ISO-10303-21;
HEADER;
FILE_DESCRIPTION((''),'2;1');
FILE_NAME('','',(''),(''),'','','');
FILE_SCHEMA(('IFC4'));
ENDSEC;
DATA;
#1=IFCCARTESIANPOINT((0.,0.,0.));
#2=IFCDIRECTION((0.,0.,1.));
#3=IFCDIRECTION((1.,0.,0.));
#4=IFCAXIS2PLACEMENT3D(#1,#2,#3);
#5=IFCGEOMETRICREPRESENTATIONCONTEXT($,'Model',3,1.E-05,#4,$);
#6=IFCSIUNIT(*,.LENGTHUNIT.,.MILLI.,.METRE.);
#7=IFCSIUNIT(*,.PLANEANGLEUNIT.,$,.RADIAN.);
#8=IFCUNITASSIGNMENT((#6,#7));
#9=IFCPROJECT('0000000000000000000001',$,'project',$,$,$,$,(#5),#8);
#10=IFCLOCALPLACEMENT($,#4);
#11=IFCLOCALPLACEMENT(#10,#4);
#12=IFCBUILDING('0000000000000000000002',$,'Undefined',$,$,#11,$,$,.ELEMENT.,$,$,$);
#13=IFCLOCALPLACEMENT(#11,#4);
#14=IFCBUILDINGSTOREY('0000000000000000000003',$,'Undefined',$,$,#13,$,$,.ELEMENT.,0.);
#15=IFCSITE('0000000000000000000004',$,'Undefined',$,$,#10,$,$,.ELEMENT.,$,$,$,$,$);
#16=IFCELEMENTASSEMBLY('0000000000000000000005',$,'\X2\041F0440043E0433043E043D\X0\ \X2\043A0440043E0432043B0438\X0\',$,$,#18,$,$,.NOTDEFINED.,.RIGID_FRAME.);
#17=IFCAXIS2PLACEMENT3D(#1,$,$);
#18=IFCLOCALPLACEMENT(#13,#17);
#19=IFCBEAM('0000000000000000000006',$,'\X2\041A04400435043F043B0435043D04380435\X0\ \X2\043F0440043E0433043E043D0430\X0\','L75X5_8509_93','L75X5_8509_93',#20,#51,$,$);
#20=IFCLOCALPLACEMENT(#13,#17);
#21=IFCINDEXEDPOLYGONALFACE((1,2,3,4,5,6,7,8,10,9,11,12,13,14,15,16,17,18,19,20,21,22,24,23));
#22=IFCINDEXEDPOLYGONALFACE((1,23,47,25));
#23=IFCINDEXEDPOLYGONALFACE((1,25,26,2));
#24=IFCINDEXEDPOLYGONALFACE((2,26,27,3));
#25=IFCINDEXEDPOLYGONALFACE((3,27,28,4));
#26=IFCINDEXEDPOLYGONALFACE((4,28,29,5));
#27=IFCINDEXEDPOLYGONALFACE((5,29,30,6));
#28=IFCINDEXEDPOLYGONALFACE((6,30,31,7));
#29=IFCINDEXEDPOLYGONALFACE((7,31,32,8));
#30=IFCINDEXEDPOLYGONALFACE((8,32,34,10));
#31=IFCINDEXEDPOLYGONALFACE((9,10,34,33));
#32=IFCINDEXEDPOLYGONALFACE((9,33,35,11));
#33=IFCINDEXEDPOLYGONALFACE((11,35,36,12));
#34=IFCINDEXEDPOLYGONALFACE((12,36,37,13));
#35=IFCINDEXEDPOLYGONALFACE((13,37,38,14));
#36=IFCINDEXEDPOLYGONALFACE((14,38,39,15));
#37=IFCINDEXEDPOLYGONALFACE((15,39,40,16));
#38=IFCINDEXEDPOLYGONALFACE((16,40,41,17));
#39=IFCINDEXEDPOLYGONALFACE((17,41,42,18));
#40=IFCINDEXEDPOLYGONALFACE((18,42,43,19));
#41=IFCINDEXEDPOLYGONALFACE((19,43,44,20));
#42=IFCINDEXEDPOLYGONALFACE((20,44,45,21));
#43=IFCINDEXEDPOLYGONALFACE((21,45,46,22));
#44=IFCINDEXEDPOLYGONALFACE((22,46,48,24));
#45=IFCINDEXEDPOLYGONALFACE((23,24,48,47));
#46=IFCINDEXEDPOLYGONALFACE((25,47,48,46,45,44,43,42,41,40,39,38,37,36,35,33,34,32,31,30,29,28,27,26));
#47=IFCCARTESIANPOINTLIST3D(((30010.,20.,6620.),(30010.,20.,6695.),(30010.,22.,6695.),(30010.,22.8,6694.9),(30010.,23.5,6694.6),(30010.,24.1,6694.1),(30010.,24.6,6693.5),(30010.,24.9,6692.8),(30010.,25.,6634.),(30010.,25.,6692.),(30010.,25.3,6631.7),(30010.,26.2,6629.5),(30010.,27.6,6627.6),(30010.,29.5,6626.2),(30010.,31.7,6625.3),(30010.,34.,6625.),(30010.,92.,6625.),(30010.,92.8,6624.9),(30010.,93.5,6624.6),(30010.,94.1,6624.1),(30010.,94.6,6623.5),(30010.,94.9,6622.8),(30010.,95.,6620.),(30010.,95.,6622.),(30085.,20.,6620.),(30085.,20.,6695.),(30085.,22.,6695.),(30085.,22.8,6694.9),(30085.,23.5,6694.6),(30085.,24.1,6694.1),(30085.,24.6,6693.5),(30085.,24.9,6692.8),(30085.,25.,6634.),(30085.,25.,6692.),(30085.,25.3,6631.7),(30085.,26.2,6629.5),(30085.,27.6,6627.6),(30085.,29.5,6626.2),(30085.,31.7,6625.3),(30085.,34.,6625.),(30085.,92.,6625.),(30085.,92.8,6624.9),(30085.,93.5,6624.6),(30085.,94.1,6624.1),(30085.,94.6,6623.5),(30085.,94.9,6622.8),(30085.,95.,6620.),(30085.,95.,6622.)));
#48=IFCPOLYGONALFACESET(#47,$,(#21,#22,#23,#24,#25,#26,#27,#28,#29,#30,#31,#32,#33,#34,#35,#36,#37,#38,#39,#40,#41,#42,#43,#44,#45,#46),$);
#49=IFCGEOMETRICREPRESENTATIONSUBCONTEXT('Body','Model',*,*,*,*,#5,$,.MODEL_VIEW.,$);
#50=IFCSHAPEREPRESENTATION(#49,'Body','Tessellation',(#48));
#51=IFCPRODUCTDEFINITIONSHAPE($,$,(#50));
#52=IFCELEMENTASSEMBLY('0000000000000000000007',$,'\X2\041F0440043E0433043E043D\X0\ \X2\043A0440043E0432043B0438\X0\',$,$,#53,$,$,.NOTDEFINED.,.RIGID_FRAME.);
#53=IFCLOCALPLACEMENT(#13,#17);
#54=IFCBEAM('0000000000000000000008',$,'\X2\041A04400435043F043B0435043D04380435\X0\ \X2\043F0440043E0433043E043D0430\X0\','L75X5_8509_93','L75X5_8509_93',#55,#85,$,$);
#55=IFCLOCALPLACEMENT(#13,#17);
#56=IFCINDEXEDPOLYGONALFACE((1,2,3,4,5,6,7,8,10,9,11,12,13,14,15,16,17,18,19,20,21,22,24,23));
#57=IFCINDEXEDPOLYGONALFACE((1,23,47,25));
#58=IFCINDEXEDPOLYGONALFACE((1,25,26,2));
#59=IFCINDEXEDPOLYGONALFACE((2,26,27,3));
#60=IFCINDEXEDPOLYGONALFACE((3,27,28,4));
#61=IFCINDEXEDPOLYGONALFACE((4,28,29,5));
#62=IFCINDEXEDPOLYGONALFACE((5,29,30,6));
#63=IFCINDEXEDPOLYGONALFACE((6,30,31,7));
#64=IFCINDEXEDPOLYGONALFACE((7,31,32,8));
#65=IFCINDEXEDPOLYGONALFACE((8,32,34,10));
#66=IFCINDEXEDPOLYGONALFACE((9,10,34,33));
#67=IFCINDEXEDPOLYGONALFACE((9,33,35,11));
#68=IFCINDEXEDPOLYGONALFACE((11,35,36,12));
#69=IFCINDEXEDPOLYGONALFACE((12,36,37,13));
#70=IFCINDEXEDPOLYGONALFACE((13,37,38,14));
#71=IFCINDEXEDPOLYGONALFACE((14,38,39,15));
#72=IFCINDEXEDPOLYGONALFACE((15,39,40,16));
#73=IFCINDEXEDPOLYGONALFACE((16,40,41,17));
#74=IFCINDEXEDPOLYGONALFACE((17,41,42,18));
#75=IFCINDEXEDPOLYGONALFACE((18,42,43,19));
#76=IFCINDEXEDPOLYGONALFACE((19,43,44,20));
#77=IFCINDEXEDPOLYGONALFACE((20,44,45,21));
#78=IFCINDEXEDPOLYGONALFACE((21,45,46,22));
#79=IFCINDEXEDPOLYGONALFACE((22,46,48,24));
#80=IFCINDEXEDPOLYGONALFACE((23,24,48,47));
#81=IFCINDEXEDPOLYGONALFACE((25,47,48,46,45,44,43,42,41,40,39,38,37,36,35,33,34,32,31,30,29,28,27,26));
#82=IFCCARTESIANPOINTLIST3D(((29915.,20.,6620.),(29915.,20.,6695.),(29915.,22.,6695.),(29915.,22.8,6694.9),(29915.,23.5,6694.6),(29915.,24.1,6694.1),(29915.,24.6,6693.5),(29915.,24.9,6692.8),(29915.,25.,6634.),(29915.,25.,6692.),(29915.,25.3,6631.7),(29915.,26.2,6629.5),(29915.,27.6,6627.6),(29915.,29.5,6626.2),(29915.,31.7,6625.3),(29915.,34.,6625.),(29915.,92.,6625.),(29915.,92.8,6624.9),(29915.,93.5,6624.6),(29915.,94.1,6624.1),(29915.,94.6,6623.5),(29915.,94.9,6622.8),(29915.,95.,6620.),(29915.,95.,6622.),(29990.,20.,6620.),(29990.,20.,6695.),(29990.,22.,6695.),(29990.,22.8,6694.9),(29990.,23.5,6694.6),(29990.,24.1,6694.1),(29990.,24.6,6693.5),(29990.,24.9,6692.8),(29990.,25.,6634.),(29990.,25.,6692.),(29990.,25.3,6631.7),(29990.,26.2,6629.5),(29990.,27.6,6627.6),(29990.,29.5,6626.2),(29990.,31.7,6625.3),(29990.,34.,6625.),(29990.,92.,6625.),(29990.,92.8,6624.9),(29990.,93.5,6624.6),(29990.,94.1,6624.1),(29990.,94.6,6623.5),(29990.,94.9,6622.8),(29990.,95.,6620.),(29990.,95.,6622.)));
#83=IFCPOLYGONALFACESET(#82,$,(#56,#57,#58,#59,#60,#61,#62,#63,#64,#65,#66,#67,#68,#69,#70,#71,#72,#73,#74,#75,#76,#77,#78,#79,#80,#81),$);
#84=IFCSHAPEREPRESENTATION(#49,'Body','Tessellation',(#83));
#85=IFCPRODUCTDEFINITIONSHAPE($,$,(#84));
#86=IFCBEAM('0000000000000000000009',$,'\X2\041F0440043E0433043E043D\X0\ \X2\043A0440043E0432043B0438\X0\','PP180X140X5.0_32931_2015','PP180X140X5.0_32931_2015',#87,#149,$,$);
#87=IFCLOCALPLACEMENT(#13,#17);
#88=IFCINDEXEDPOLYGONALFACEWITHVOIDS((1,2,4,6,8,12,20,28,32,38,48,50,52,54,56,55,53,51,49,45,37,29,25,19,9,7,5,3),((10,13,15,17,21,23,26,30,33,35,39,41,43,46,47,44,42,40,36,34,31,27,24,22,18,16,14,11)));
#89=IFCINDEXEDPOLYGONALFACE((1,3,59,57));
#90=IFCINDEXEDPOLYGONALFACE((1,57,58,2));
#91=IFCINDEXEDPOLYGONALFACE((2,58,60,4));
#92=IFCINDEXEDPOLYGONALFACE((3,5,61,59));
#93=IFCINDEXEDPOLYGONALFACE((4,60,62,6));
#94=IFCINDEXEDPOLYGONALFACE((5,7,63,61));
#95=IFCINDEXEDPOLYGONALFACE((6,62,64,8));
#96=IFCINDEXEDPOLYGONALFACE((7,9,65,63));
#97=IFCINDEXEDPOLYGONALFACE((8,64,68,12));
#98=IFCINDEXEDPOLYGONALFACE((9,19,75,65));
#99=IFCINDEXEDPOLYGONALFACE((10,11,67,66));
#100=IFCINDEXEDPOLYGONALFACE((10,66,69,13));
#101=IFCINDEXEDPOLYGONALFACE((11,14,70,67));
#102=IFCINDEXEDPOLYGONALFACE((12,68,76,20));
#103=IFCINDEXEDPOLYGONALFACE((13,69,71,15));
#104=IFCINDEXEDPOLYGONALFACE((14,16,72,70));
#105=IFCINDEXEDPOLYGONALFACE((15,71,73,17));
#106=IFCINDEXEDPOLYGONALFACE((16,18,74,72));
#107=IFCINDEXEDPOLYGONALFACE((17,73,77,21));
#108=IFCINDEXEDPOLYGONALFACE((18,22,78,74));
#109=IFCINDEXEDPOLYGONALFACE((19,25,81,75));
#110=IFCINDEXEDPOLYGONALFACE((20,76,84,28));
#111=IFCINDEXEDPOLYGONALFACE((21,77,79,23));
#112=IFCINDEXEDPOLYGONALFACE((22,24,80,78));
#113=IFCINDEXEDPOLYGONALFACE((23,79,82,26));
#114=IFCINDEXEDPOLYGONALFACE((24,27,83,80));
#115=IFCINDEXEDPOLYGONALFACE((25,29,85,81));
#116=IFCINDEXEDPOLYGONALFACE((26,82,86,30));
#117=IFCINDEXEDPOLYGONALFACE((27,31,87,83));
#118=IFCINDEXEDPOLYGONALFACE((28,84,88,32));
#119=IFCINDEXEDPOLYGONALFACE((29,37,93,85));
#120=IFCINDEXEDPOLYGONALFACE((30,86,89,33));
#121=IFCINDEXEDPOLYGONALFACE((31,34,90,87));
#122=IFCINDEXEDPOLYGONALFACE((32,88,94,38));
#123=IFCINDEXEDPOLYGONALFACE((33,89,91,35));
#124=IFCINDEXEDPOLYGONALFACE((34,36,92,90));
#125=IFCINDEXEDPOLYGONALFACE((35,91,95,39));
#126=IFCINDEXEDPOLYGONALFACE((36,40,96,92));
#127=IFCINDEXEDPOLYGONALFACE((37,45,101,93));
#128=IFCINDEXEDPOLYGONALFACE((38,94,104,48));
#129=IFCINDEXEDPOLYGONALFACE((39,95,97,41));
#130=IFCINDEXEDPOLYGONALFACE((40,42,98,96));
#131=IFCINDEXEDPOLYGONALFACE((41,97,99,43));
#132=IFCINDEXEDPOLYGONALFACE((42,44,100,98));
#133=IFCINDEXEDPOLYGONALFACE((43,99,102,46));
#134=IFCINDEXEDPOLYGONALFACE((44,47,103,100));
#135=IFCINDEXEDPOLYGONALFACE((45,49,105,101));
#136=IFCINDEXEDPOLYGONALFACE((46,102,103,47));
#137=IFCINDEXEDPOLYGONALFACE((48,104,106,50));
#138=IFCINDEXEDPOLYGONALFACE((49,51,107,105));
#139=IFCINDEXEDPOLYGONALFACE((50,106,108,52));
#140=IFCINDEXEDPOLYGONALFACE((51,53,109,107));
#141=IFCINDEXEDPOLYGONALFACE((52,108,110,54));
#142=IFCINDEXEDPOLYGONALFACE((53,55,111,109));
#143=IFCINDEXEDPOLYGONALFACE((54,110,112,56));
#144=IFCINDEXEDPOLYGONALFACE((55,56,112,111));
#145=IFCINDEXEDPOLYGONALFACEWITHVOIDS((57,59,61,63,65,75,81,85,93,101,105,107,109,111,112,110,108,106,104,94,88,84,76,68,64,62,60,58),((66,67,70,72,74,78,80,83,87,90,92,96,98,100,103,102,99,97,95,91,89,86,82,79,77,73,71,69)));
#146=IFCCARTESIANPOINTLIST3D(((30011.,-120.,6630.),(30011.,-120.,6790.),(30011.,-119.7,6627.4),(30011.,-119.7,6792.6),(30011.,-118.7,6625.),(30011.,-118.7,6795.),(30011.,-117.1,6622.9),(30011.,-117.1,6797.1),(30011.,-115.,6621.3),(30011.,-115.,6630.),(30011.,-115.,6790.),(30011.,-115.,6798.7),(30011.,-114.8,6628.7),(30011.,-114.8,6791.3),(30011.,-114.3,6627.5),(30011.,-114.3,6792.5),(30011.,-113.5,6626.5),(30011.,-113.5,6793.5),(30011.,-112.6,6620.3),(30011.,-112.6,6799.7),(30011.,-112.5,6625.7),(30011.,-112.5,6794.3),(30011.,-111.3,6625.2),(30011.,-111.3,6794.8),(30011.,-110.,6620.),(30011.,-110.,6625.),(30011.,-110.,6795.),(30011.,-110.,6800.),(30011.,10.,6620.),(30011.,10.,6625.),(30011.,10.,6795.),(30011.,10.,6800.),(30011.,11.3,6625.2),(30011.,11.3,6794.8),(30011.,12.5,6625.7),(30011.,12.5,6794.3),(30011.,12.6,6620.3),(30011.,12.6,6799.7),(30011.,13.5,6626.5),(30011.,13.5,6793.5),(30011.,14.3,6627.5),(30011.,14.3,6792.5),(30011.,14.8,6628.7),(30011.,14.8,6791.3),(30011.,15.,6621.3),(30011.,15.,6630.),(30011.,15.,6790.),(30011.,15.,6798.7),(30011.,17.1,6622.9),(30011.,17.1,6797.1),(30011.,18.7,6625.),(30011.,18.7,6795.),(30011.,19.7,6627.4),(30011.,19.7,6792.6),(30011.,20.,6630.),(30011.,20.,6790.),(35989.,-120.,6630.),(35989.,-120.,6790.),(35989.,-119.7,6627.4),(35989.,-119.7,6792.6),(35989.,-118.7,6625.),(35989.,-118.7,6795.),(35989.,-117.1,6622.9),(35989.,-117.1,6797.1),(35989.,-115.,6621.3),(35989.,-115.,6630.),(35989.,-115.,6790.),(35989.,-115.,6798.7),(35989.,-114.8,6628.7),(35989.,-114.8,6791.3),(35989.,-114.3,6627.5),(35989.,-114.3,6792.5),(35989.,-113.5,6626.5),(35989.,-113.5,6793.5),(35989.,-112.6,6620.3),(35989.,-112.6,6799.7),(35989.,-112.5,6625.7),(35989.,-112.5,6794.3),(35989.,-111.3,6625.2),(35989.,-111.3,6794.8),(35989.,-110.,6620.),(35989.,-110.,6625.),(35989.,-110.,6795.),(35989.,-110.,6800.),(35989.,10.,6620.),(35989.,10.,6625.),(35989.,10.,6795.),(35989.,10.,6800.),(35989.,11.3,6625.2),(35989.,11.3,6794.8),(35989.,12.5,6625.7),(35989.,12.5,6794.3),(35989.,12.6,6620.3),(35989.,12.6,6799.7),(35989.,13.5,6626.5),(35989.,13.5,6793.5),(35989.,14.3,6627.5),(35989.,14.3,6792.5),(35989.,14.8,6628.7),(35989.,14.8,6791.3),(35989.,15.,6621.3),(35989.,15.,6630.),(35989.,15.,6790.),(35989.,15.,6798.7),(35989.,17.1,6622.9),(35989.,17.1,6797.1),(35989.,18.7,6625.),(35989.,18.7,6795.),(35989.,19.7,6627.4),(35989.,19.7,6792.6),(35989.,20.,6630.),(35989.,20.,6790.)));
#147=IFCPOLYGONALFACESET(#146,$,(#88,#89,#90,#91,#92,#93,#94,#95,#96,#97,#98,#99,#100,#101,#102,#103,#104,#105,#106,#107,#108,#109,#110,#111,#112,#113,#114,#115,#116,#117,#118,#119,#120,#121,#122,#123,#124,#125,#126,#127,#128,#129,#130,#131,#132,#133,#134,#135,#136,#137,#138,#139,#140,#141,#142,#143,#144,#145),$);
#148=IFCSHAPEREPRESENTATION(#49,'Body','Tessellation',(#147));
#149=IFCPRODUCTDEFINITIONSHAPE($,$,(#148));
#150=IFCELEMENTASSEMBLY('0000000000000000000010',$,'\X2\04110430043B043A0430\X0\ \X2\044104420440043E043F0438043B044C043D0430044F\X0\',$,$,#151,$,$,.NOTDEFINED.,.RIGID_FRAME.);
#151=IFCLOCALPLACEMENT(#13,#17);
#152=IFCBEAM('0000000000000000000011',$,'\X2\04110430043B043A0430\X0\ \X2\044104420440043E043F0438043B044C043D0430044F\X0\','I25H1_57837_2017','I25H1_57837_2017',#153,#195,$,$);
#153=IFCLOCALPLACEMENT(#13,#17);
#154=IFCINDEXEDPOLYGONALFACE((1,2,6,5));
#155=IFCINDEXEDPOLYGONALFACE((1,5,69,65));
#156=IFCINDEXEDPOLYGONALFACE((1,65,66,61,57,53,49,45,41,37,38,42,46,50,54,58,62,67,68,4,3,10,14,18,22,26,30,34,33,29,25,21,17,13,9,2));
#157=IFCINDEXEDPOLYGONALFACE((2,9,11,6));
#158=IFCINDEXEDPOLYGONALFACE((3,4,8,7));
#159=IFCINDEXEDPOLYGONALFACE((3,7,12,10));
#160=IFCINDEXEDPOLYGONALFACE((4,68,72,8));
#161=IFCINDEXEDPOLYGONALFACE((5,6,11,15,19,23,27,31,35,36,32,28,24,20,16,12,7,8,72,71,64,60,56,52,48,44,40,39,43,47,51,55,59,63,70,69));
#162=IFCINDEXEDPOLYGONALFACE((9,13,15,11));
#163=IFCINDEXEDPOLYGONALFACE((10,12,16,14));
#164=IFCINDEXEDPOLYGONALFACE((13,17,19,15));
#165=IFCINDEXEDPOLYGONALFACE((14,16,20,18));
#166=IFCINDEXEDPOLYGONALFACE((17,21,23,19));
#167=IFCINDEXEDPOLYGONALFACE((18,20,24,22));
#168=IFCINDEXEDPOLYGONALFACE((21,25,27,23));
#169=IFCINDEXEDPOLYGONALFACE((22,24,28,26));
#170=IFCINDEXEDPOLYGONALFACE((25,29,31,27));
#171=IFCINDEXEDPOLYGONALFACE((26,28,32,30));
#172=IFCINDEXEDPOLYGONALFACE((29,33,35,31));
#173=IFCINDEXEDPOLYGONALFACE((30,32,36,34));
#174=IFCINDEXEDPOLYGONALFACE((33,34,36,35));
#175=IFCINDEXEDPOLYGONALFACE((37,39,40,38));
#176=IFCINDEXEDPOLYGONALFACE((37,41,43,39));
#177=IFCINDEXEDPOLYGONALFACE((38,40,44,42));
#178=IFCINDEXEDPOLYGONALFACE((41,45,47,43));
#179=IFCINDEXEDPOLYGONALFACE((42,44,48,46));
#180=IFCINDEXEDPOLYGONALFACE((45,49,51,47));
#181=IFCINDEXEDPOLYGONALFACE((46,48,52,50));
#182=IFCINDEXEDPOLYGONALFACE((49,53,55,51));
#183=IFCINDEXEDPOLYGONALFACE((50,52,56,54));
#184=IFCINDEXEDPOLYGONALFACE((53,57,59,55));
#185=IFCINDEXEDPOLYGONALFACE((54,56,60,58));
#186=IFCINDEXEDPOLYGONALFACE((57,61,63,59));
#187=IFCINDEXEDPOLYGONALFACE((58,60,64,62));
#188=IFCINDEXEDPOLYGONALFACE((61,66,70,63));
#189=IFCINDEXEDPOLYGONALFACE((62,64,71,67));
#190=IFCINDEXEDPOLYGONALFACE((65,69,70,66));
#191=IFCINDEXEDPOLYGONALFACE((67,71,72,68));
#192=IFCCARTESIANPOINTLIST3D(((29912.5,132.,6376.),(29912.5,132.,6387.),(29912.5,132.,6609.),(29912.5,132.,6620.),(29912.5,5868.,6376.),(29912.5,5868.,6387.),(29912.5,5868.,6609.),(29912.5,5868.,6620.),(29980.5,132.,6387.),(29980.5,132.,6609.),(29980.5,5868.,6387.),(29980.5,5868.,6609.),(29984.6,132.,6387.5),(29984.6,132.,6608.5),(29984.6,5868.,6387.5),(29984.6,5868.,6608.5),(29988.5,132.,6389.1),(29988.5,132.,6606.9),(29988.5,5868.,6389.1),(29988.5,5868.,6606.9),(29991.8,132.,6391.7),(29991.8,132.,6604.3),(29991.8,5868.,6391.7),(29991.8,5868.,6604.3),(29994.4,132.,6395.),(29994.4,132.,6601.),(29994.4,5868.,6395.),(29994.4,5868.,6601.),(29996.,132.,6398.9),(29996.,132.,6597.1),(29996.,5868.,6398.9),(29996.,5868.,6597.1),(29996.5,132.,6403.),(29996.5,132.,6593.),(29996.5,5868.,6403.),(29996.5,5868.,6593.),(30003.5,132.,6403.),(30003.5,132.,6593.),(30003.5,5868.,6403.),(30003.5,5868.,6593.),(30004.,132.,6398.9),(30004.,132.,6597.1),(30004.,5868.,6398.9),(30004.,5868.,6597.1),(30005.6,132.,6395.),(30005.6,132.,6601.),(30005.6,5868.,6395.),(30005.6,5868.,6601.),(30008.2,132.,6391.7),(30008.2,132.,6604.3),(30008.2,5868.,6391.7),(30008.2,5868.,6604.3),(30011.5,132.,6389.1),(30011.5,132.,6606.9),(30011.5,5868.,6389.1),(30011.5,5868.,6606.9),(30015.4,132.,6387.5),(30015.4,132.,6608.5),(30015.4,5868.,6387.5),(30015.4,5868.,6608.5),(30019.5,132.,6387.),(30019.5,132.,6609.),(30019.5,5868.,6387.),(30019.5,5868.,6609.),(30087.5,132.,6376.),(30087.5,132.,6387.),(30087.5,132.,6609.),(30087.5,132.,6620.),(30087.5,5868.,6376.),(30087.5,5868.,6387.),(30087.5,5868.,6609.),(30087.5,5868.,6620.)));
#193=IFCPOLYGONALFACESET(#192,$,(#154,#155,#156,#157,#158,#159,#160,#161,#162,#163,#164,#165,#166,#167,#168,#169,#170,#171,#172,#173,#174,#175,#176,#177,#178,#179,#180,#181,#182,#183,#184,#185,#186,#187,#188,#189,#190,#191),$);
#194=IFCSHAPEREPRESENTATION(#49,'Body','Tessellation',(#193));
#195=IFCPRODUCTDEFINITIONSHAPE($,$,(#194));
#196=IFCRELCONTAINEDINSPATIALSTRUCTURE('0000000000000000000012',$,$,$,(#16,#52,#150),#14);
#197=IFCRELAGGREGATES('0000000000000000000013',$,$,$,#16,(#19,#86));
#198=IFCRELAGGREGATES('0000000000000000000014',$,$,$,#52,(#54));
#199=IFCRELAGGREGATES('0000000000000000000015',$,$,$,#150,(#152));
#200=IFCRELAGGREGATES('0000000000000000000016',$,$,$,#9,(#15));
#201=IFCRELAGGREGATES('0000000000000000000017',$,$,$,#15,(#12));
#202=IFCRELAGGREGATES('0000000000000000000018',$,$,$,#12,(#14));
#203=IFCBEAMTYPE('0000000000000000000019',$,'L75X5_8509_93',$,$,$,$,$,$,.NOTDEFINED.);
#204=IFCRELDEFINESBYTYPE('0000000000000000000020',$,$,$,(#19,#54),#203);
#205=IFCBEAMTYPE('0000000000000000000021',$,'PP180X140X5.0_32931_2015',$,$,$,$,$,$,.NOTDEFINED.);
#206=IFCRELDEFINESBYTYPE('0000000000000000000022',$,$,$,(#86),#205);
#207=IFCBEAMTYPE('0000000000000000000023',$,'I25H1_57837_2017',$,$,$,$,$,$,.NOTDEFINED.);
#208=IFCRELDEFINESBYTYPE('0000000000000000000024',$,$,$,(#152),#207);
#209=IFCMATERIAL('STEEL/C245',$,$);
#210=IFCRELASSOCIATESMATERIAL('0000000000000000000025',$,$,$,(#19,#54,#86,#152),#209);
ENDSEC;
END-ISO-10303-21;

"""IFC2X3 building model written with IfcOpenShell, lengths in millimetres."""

from ifc_helpers import new_model, si_unit, frame, origin_with_axes, origin_2d_with_axis, place, context, subcontext, project, spatial, hollow_rectangle, i_section, l_section, extrude, clip, halfspace, material, type_object, element, aggregate, save


model = new_model("IFC2X3")

# Units and contexts
model_context = context("Model", 3, precision=1e-05, world=origin_with_axes())
body_context = subcontext(model_context, "Body", "Model", "MODEL_VIEW")
ifc_project = project(units=[si_unit("LENGTHUNIT", "METRE", prefix="MILLI"), si_unit("PLANEANGLEUNIT", "RADIAN")], contexts=[model_context])

# Site, building, storey
site_placement = place(None, origin_with_axes())
site = spatial("IfcSite", under=ifc_project, at=site_placement, Name="Undefined", CompositionType="ELEMENT")
building_placement = place(site_placement, origin_with_axes())
building = spatial("IfcBuilding", under=site, at=building_placement, Name="Undefined", CompositionType="ELEMENT")
storey_placement = place(building_placement, origin_with_axes())
storey = spatial("IfcBuildingStorey", under=building, at=storey_placement, Name="Undefined", CompositionType="ELEMENT", Elevation=0.0)

# Element assemblies, beams
ifc_material_1 = material(Name="STEEL/C245")
assembly_1_placement = place(storey_placement, origin_with_axes())
assembly_1 = element("IfcElementAssembly", 1, at=assembly_1_placement, inside=storey, Name="Прогон кровли", AssemblyPlace="NOTDEFINED", PredefinedType="RIGID_FRAME")
beam_type_1 = type_object("IfcBeamType", Name="L75X5_8509_93", PredefinedType="NOTDEFINED")
beam_1_placement = place(assembly_1_placement, frame((30010.0, 57.5, 6657.5), z_axis=(0.0, 1.0, 0.0), x_axis=(1.0, 0.0, 0.0)))
beam_1 = element("IfcBeam", 2, at=beam_1_placement, type_object=beam_type_1, material=ifc_material_1, Name="Крепление прогона", Description="L75X5_8509_93", ObjectType="L75X5_8509_93", context=body_context, shape_type="SweptSolid", body=[
    extrude(l_section(Depth=75.0, Width=75.0, Thickness=5.0, FilletRadius=9.0, EdgeRadius=3.0, at=origin_2d_with_axis()), frame((75.0, 0.0, 0.0), z_axis=(-1.0, 0.0, 0.0), x_axis=(0.0, -1.0, 0.0)), (0.0, 0.0, 1.0), 75.0),
])
assembly_2_placement = place(storey_placement, origin_with_axes())
assembly_2 = element("IfcElementAssembly", 3, at=assembly_2_placement, inside=storey, Name="Прогон кровли", AssemblyPlace="NOTDEFINED", PredefinedType="RIGID_FRAME")
beam_2_placement = place(assembly_2_placement, frame((29915.0, 57.5, 6657.5), z_axis=(0.0, 1.0, 0.0), x_axis=(1.0, 0.0, 0.0)))
beam_2 = element("IfcBeam", 4, at=beam_2_placement, type_object=beam_type_1, material=ifc_material_1, Name="Крепление прогона", Description="L75X5_8509_93", ObjectType="L75X5_8509_93", context=body_context, shape_type="SweptSolid", body=[
    extrude(l_section(Depth=75.0, Width=75.0, Thickness=5.0, FilletRadius=9.0, EdgeRadius=3.0, at=origin_2d_with_axis()), frame((75.0, 0.0, 0.0), z_axis=(-1.0, 0.0, 0.0), x_axis=(0.0, -1.0, 0.0)), (0.0, 0.0, 1.0), 75.0),
])

# Beam
beam_type_2 = type_object("IfcBeamType", Name="PP180X140X5.0_32931_2015", PredefinedType="NOTDEFINED")
beam_3_placement = place(assembly_1_placement, frame((30013.0, -50.0, 6710.0), z_axis=(0.0, 0.0, 1.0), x_axis=(1.0, 0.0, 0.0)))
beam_3 = element("IfcBeam", 5, at=beam_3_placement, type_object=beam_type_2, material=ifc_material_1, Name="Прогон кровли", Description="PP180X140X5.0_32931_2015", ObjectType="PP180X140X5.0_32931_2015", context=body_context, shape_type="Clipping", body=[
    clip(clip(extrude(hollow_rectangle(XDim=140.0, YDim=180.0, WallThickness=5.0, InnerFilletRadius=5.0, OuterFilletRadius=10.0, at=origin_2d_with_axis()), frame((5976.0, 0.0, 0.0), z_axis=(-1.0, 0.0, 0.0), x_axis=(0.0, -1.0, 0.0)), (0.0, 0.0, 1.0), 5978.0), halfspace(frame((5976.0, 0.0, -90.0), z_axis=(-1.0, 0.0, 0.0), x_axis=(0.0, 1.0, 0.0)), True)), halfspace(frame((-2.0, 0.0, -90.0), z_axis=(1.0, 0.0, 0.0), x_axis=(0.0, -1.0, 0.0)), True)),
])

# Element assembly, beam
assembly_3_placement = place(storey_placement, origin_with_axes())
assembly_3 = element("IfcElementAssembly", 6, at=assembly_3_placement, inside=storey, Name="Балка стропильная", AssemblyPlace="NOTDEFINED", PredefinedType="RIGID_FRAME")
beam_type_3 = type_object("IfcBeamType", Name="I25H1_57837_2017", PredefinedType="NOTDEFINED")
beam_4_placement = place(assembly_3_placement, frame((30000.0, 132.0, 6498.0), z_axis=(0.0, 0.0, 1.0), x_axis=(0.0, 1.0, 0.0)))
beam_4 = element("IfcBeam", 7, at=beam_4_placement, type_object=beam_type_3, material=ifc_material_1, Name="Балка стропильная", Description="I25H1_57837_2017", ObjectType="I25H1_57837_2017", context=body_context, shape_type="SweptSolid", body=[
    extrude(i_section(OverallWidth=175.0, OverallDepth=244.0, WebThickness=7.0, FlangeThickness=11.0, FilletRadius=16.0, at=origin_2d_with_axis()), frame((5736.0, 0.0, 0.0), z_axis=(-1.0, 0.0, 0.0), x_axis=(0.0, -1.0, 0.0)), (0.0, 0.0, 1.0), 5736.0),
])

aggregate(assembly_1, [beam_1, beam_3])
aggregate(assembly_2, [beam_2])
aggregate(assembly_3, [beam_4])

save(model, "model.ifc")
